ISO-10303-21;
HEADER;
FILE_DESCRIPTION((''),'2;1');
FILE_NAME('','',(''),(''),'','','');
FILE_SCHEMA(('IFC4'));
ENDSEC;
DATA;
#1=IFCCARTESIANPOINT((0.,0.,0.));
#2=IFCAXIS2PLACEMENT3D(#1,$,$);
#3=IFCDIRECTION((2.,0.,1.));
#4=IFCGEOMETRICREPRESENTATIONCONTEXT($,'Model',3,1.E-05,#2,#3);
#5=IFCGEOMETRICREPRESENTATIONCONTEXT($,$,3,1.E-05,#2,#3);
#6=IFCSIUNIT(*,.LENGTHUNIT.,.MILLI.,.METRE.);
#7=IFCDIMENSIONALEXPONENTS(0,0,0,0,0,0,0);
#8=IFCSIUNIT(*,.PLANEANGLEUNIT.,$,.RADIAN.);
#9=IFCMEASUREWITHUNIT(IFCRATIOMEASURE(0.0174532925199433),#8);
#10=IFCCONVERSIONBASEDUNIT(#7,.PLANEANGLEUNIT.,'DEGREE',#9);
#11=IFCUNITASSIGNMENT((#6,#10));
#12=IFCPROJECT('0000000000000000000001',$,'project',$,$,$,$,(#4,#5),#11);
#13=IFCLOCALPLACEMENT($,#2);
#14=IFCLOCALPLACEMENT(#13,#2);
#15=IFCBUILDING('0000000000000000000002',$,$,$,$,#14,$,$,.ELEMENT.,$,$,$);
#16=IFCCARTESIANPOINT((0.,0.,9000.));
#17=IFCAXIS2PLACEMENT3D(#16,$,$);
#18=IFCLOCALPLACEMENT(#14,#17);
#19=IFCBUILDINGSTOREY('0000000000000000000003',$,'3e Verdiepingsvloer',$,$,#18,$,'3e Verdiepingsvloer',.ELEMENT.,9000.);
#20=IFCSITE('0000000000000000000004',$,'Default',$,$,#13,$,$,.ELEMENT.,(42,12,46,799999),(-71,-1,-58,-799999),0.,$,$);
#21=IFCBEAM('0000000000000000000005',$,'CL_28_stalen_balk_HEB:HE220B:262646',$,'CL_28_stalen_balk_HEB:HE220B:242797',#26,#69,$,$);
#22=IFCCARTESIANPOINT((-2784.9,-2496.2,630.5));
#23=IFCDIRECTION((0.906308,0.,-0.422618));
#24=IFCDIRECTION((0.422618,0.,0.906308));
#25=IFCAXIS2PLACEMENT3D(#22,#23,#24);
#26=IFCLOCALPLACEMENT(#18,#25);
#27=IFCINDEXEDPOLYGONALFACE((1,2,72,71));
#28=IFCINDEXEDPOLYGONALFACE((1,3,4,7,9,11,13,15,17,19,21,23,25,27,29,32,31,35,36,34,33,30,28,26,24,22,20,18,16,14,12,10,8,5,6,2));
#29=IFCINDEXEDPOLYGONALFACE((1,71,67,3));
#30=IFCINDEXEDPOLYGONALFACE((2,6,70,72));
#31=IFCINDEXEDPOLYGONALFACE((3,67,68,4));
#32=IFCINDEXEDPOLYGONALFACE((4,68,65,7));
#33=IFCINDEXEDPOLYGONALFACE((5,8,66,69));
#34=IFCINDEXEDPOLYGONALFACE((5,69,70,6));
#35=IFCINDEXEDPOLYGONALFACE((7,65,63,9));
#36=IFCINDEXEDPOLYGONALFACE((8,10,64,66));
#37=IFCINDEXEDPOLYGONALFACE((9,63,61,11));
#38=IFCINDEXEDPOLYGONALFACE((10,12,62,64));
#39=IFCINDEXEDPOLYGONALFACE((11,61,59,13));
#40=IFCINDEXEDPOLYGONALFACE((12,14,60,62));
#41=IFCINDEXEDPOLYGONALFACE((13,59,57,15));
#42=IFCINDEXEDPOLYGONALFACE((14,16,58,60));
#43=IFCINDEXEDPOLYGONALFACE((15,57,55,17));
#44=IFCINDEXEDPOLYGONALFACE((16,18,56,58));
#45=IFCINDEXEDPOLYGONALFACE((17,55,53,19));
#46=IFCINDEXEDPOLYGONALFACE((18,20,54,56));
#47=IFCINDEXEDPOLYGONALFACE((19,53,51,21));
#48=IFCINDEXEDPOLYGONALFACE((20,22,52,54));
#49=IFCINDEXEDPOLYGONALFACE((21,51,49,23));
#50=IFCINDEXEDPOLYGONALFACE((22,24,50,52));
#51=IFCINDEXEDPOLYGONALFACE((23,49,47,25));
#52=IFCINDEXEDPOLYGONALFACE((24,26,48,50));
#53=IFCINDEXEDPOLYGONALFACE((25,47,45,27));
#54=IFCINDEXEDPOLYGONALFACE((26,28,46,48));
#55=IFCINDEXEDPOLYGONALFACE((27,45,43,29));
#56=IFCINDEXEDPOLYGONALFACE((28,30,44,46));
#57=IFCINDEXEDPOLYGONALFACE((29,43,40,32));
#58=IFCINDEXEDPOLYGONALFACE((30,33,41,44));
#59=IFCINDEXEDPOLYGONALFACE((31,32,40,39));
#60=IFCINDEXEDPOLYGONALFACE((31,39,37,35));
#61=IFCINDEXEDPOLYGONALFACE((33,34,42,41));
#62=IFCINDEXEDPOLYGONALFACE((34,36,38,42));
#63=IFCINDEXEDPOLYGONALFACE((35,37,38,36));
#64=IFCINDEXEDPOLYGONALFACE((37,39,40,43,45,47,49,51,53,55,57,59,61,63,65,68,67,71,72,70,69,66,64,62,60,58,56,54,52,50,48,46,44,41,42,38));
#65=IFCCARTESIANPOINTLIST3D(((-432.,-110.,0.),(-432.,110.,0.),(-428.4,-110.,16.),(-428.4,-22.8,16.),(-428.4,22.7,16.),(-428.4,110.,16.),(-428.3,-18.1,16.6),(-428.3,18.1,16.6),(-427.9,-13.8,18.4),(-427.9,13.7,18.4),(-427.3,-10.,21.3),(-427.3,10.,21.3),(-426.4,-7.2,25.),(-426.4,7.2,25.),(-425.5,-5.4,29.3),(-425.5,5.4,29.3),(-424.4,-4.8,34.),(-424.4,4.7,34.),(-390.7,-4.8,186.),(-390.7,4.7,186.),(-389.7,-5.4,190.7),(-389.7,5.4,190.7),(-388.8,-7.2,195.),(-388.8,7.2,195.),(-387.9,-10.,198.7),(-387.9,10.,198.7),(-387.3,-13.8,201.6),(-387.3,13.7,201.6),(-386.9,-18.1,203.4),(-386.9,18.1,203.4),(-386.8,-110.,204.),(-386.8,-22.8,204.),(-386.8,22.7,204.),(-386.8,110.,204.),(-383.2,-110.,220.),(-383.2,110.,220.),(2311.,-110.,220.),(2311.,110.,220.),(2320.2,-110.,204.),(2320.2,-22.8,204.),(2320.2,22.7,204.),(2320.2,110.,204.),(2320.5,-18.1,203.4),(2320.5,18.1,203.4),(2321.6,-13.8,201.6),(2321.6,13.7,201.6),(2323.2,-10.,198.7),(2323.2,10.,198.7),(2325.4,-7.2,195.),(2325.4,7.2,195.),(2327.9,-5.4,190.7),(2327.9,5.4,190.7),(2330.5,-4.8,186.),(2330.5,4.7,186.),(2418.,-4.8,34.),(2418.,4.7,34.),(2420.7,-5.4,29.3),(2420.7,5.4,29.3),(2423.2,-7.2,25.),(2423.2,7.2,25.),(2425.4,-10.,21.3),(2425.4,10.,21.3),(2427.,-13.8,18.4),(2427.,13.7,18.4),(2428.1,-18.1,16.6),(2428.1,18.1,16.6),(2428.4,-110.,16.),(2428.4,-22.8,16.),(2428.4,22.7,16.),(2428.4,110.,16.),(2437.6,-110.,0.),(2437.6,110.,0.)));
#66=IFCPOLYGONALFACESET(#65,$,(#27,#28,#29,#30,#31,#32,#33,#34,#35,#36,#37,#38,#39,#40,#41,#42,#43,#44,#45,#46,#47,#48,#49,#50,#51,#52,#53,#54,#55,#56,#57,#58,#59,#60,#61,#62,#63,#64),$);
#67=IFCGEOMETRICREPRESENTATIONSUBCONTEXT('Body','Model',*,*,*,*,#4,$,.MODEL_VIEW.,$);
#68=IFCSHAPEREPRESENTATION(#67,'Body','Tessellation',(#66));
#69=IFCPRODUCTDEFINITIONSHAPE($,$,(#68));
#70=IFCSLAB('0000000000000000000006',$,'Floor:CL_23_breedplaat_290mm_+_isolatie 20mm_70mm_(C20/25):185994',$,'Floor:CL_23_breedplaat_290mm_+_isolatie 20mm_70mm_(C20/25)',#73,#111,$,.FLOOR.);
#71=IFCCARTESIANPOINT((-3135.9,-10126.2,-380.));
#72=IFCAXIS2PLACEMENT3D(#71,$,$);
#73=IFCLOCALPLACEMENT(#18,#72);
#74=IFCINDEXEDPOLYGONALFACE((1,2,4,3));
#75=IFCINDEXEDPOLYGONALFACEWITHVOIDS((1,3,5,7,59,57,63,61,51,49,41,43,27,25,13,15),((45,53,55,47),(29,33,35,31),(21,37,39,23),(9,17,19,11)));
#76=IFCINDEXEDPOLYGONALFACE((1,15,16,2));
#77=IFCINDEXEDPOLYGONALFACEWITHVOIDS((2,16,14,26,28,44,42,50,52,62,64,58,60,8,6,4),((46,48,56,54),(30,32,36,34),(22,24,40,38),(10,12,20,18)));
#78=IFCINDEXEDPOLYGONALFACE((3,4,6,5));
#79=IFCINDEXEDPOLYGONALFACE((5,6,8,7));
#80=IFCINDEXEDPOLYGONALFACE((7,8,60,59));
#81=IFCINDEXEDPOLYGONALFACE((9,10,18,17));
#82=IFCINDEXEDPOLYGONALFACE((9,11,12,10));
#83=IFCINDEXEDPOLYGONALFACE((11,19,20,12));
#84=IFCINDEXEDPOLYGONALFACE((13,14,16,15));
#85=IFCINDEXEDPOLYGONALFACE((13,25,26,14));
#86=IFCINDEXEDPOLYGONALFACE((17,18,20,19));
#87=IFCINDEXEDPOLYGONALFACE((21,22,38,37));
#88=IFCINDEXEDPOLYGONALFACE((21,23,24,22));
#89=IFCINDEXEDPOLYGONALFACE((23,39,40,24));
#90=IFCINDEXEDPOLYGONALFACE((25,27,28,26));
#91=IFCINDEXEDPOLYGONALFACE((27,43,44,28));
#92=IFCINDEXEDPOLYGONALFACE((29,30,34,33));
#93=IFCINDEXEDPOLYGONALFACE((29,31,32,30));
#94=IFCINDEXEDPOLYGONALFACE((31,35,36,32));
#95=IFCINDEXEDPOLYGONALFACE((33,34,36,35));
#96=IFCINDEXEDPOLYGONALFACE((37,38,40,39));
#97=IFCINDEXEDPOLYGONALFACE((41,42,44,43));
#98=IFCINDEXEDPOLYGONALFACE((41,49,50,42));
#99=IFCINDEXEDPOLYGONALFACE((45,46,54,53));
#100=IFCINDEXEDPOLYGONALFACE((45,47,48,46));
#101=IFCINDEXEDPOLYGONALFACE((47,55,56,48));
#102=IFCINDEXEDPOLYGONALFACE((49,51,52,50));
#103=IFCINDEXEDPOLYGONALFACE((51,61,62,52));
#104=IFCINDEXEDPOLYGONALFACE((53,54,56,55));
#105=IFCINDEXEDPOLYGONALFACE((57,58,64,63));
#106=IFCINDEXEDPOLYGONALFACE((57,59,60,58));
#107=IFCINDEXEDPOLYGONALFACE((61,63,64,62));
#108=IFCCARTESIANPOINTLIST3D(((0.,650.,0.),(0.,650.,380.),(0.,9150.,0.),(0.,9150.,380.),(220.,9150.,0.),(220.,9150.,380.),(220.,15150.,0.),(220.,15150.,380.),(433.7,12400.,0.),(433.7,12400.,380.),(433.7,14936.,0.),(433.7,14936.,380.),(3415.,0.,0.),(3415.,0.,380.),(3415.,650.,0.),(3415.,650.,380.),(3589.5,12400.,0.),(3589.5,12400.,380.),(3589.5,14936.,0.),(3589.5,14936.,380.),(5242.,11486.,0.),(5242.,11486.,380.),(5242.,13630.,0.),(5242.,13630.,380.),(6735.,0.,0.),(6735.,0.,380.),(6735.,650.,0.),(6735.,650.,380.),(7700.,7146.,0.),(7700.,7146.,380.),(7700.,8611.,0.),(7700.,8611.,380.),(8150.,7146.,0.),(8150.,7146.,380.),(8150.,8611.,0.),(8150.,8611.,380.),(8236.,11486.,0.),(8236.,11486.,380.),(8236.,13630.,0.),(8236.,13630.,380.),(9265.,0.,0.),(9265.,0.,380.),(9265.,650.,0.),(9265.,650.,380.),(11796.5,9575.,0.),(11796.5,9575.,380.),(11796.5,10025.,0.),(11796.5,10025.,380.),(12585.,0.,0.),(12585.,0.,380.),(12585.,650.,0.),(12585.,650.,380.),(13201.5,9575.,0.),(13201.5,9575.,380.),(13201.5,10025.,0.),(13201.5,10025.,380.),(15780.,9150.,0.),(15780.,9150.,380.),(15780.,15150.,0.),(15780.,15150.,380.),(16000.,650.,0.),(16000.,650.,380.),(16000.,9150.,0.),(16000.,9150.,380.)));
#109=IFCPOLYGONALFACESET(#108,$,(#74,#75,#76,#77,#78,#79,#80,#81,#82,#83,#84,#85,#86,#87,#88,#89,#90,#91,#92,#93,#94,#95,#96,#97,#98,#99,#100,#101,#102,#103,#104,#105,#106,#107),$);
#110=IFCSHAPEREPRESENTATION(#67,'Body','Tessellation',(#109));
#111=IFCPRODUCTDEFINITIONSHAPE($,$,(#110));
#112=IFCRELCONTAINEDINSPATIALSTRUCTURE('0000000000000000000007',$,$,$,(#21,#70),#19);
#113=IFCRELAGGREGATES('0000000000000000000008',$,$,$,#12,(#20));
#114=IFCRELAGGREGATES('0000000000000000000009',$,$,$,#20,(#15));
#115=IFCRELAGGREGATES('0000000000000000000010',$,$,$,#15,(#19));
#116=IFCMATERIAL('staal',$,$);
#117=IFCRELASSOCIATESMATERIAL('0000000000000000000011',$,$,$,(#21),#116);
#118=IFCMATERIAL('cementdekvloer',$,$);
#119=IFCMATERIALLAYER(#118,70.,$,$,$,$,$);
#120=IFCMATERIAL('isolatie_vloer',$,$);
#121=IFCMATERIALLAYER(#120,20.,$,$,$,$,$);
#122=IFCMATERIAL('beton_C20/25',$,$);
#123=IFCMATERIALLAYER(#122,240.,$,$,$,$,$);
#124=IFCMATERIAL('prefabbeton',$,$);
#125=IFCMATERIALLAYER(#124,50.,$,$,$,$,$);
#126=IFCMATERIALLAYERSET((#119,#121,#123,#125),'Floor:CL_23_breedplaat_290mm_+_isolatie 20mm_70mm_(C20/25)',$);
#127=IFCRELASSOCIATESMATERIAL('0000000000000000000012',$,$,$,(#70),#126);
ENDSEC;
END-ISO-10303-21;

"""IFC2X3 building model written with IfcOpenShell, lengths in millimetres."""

from ifc_helpers import new_model, entity, si_unit, converted_unit, direction, frame, frame_2d, origin, origin_2d_with_axis, place, context, subcontext, project, spatial, polyline, rectangle, i_section, outline, extrude, clip, halfspace, material, layer, layer_set, layer_usage, element, save


model = new_model("IFC2X3")

# Units and contexts
model_context = context("Model", 3, precision=1e-05, world=origin(), true_north=direction((2.0, 0.0, 1.0)))
context_of_model = context(None, 3, precision=1e-05, world=origin(), true_north=direction((2.0, 0.0, 1.0)))
body_context = subcontext(model_context, "Body", "Model", "MODEL_VIEW")
ifc_project = project(units=[si_unit("LENGTHUNIT", "METRE", prefix="MILLI"), converted_unit("PLANEANGLEUNIT", "DEGREE", entity("IfcRatioMeasure", 0.0174532925199433), si_unit("PLANEANGLEUNIT", "RADIAN"), dimensions=[0, 0, 0, 0, 0, 0, 0])], contexts=[model_context, context_of_model])

# Site, building, storey
site_placement = place(None, origin())
site = spatial("IfcSite", under=ifc_project, at=site_placement, Name="Default", CompositionType="ELEMENT", RefLatitude=(42, 12, 46, 799999), RefLongitude=(-71, -1, -58, -799999), RefElevation=0.0)
building_placement = place(site_placement, origin())
building = spatial("IfcBuilding", under=site, at=building_placement, CompositionType="ELEMENT")
storey_placement = place(building_placement, frame((0.0, 0.0, 9000.0)))
storey = spatial("IfcBuildingStorey", under=building, at=storey_placement, Name="3e Verdiepingsvloer", LongName="3e Verdiepingsvloer", CompositionType="ELEMENT", Elevation=9000.0)

# Beam
ifc_material_1 = material(Name="staal")
beam_1_placement = place(storey_placement, frame((-2784.9, -2496.2, 630.5), z_axis=(0.906308, 0.0, -0.422618), x_axis=(0.422618, 0.0, 0.906308)))
element("IfcBeam", 1, at=beam_1_placement, inside=storey, material=ifc_material_1, Name="CL_28_stalen_balk_HEB:HE220B:262646", ObjectType="CL_28_stalen_balk_HEB:HE220B:242797", context=body_context, shape_type="Clipping", body=[
    clip(clip(extrude(i_section(OverallWidth=220.0, OverallDepth=220.0, WebThickness=9.5, FlangeThickness=16.0, FilletRadius=18.0, at=frame_2d((0.0, 0.0), x_axis=(0.0, 1.0))), frame((-432.0, 0.0, 110.0), z_axis=(1.0, 0.0, 0.0), x_axis=(0.0, 0.0, -1.0)), (0.0, 0.0, 1.0), 2869.6), halfspace(frame((-500.2, -667.6, -307.6), z_axis=(-0.976296, 0.0, 0.21644), x_axis=(0.21644, 0.0, 0.976296)), False)), halfspace(frame((2444.9, 5856.2, -12.6), z_axis=(0.86662, 0.0, 0.498969), x_axis=(-0.498969, 0.0, 0.86662)), False)),
])

# Slab, openings
ifc_material_2 = material(Name="cementdekvloer")
ifc_layer_1 = layer(ifc_material_2, 70.0)
ifc_material_3 = material(Name="isolatie_vloer")
ifc_layer_2 = layer(ifc_material_3, 20.0)
ifc_material_4 = material(Name="beton_C20/25")
ifc_layer_3 = layer(ifc_material_4, 240.0)
ifc_material_5 = material(Name="prefabbeton")
ifc_layer_4 = layer(ifc_material_5, 50.0)
ifc_layer_set_1 = layer_set([ifc_layer_1, ifc_layer_2, ifc_layer_3, ifc_layer_4], Name="Floor:CL_23_breedplaat_290mm_+_isolatie 20mm_70mm_(C20/25)")
ifc_layer_usage_1 = layer_usage(ifc_layer_set_1, "AXIS3", "POSITIVE", 0.0)
slab_placement = place(storey_placement, frame((-3135.9, -10126.2, -380.0)))
slab = element("IfcSlab", 2, at=slab_placement, inside=storey, material=ifc_layer_usage_1, Name="Floor:CL_23_breedplaat_290mm_+_isolatie 20mm_70mm_(C20/25):185994", ObjectType="Floor:CL_23_breedplaat_290mm_+_isolatie 20mm_70mm_(C20/25)", PredefinedType="FLOOR", context=body_context, shape_type="SweptSolid", body=[
    extrude(outline(polyline([(7780.0, 7575.0), (-7780.0, 7575.0), (-7780.0, 1575.0), (-8000.0, 1575.0), (-8000.0, -6925.0), (-4585.0, -6925.0), (-4585.0, -7575.0), (-1265.0, -7575.0), (-1265.0, -6925.0), (1265.0, -6925.0), (1265.0, -7575.0), (4585.0, -7575.0), (4585.0, -6925.0), (8000.0, -6925.0), (8000.0, 1575.0), (7780.0, 1575.0), (7780.0, 7575.0)])), frame((8000.0, 7575.0, 380.0), z_axis=(0.0, 0.0, -1.0), x_axis=(-1.0, 0.0, 0.0)), (0.0, 0.0, 1.0), 380.0),
])
opening_1_placement = place(slab_placement, frame((2011.6, 13668.0, 380.0)))
element("IfcOpeningElement", 3, at=opening_1_placement, cuts=slab, ObjectType="Opening", context=body_context, shape_type="SweptSolid", body=[
    extrude(rectangle(XDim=3155.8, YDim=2536.0, at=origin_2d_with_axis()), frame((0.0, 0.0, 0.0), z_axis=(0.0, 0.0, -1.0), x_axis=(-1.0, 0.0, 0.0)), (0.0, 0.0, 1.0), 380.0),
])
opening_2_placement = place(slab_placement, frame((6739.0, 12558.0, 380.0)))
element("IfcOpeningElement", 4, at=opening_2_placement, cuts=slab, ObjectType="Opening", context=body_context, shape_type="SweptSolid", body=[
    extrude(rectangle(XDim=2144.0, YDim=2994.0, at=origin_2d_with_axis()), frame((0.0, 0.0, 0.0), z_axis=(0.0, 0.0, -1.0), x_axis=(0.0, -1.0, 0.0)), (0.0, 0.0, 1.0), 380.0),
])
opening_3_placement = place(slab_placement, frame((12499.0, 9800.0, 380.0)))
element("IfcOpeningElement", 5, at=opening_3_placement, cuts=slab, ObjectType="Opening", context=body_context, shape_type="SweptSolid", body=[
    extrude(rectangle(XDim=450.0, YDim=1405.0, at=origin_2d_with_axis()), frame((0.0, 0.0, 0.0), z_axis=(0.0, 0.0, -1.0), x_axis=(0.0, -1.0, 0.0)), (0.0, 0.0, 1.0), 380.0),
])
opening_4_placement = place(slab_placement, frame((7925.0, 7878.5, 380.0)))
element("IfcOpeningElement", 6, at=opening_4_placement, cuts=slab, ObjectType="Opening", context=body_context, shape_type="SweptSolid", body=[
    extrude(rectangle(XDim=1465.0, YDim=450.0, at=origin_2d_with_axis()), frame((0.0, 0.0, 0.0), z_axis=(0.0, 0.0, -1.0), x_axis=(0.0, -1.0, 0.0)), (0.0, 0.0, 1.0), 380.0),
])

save(model, "model.ifc")
